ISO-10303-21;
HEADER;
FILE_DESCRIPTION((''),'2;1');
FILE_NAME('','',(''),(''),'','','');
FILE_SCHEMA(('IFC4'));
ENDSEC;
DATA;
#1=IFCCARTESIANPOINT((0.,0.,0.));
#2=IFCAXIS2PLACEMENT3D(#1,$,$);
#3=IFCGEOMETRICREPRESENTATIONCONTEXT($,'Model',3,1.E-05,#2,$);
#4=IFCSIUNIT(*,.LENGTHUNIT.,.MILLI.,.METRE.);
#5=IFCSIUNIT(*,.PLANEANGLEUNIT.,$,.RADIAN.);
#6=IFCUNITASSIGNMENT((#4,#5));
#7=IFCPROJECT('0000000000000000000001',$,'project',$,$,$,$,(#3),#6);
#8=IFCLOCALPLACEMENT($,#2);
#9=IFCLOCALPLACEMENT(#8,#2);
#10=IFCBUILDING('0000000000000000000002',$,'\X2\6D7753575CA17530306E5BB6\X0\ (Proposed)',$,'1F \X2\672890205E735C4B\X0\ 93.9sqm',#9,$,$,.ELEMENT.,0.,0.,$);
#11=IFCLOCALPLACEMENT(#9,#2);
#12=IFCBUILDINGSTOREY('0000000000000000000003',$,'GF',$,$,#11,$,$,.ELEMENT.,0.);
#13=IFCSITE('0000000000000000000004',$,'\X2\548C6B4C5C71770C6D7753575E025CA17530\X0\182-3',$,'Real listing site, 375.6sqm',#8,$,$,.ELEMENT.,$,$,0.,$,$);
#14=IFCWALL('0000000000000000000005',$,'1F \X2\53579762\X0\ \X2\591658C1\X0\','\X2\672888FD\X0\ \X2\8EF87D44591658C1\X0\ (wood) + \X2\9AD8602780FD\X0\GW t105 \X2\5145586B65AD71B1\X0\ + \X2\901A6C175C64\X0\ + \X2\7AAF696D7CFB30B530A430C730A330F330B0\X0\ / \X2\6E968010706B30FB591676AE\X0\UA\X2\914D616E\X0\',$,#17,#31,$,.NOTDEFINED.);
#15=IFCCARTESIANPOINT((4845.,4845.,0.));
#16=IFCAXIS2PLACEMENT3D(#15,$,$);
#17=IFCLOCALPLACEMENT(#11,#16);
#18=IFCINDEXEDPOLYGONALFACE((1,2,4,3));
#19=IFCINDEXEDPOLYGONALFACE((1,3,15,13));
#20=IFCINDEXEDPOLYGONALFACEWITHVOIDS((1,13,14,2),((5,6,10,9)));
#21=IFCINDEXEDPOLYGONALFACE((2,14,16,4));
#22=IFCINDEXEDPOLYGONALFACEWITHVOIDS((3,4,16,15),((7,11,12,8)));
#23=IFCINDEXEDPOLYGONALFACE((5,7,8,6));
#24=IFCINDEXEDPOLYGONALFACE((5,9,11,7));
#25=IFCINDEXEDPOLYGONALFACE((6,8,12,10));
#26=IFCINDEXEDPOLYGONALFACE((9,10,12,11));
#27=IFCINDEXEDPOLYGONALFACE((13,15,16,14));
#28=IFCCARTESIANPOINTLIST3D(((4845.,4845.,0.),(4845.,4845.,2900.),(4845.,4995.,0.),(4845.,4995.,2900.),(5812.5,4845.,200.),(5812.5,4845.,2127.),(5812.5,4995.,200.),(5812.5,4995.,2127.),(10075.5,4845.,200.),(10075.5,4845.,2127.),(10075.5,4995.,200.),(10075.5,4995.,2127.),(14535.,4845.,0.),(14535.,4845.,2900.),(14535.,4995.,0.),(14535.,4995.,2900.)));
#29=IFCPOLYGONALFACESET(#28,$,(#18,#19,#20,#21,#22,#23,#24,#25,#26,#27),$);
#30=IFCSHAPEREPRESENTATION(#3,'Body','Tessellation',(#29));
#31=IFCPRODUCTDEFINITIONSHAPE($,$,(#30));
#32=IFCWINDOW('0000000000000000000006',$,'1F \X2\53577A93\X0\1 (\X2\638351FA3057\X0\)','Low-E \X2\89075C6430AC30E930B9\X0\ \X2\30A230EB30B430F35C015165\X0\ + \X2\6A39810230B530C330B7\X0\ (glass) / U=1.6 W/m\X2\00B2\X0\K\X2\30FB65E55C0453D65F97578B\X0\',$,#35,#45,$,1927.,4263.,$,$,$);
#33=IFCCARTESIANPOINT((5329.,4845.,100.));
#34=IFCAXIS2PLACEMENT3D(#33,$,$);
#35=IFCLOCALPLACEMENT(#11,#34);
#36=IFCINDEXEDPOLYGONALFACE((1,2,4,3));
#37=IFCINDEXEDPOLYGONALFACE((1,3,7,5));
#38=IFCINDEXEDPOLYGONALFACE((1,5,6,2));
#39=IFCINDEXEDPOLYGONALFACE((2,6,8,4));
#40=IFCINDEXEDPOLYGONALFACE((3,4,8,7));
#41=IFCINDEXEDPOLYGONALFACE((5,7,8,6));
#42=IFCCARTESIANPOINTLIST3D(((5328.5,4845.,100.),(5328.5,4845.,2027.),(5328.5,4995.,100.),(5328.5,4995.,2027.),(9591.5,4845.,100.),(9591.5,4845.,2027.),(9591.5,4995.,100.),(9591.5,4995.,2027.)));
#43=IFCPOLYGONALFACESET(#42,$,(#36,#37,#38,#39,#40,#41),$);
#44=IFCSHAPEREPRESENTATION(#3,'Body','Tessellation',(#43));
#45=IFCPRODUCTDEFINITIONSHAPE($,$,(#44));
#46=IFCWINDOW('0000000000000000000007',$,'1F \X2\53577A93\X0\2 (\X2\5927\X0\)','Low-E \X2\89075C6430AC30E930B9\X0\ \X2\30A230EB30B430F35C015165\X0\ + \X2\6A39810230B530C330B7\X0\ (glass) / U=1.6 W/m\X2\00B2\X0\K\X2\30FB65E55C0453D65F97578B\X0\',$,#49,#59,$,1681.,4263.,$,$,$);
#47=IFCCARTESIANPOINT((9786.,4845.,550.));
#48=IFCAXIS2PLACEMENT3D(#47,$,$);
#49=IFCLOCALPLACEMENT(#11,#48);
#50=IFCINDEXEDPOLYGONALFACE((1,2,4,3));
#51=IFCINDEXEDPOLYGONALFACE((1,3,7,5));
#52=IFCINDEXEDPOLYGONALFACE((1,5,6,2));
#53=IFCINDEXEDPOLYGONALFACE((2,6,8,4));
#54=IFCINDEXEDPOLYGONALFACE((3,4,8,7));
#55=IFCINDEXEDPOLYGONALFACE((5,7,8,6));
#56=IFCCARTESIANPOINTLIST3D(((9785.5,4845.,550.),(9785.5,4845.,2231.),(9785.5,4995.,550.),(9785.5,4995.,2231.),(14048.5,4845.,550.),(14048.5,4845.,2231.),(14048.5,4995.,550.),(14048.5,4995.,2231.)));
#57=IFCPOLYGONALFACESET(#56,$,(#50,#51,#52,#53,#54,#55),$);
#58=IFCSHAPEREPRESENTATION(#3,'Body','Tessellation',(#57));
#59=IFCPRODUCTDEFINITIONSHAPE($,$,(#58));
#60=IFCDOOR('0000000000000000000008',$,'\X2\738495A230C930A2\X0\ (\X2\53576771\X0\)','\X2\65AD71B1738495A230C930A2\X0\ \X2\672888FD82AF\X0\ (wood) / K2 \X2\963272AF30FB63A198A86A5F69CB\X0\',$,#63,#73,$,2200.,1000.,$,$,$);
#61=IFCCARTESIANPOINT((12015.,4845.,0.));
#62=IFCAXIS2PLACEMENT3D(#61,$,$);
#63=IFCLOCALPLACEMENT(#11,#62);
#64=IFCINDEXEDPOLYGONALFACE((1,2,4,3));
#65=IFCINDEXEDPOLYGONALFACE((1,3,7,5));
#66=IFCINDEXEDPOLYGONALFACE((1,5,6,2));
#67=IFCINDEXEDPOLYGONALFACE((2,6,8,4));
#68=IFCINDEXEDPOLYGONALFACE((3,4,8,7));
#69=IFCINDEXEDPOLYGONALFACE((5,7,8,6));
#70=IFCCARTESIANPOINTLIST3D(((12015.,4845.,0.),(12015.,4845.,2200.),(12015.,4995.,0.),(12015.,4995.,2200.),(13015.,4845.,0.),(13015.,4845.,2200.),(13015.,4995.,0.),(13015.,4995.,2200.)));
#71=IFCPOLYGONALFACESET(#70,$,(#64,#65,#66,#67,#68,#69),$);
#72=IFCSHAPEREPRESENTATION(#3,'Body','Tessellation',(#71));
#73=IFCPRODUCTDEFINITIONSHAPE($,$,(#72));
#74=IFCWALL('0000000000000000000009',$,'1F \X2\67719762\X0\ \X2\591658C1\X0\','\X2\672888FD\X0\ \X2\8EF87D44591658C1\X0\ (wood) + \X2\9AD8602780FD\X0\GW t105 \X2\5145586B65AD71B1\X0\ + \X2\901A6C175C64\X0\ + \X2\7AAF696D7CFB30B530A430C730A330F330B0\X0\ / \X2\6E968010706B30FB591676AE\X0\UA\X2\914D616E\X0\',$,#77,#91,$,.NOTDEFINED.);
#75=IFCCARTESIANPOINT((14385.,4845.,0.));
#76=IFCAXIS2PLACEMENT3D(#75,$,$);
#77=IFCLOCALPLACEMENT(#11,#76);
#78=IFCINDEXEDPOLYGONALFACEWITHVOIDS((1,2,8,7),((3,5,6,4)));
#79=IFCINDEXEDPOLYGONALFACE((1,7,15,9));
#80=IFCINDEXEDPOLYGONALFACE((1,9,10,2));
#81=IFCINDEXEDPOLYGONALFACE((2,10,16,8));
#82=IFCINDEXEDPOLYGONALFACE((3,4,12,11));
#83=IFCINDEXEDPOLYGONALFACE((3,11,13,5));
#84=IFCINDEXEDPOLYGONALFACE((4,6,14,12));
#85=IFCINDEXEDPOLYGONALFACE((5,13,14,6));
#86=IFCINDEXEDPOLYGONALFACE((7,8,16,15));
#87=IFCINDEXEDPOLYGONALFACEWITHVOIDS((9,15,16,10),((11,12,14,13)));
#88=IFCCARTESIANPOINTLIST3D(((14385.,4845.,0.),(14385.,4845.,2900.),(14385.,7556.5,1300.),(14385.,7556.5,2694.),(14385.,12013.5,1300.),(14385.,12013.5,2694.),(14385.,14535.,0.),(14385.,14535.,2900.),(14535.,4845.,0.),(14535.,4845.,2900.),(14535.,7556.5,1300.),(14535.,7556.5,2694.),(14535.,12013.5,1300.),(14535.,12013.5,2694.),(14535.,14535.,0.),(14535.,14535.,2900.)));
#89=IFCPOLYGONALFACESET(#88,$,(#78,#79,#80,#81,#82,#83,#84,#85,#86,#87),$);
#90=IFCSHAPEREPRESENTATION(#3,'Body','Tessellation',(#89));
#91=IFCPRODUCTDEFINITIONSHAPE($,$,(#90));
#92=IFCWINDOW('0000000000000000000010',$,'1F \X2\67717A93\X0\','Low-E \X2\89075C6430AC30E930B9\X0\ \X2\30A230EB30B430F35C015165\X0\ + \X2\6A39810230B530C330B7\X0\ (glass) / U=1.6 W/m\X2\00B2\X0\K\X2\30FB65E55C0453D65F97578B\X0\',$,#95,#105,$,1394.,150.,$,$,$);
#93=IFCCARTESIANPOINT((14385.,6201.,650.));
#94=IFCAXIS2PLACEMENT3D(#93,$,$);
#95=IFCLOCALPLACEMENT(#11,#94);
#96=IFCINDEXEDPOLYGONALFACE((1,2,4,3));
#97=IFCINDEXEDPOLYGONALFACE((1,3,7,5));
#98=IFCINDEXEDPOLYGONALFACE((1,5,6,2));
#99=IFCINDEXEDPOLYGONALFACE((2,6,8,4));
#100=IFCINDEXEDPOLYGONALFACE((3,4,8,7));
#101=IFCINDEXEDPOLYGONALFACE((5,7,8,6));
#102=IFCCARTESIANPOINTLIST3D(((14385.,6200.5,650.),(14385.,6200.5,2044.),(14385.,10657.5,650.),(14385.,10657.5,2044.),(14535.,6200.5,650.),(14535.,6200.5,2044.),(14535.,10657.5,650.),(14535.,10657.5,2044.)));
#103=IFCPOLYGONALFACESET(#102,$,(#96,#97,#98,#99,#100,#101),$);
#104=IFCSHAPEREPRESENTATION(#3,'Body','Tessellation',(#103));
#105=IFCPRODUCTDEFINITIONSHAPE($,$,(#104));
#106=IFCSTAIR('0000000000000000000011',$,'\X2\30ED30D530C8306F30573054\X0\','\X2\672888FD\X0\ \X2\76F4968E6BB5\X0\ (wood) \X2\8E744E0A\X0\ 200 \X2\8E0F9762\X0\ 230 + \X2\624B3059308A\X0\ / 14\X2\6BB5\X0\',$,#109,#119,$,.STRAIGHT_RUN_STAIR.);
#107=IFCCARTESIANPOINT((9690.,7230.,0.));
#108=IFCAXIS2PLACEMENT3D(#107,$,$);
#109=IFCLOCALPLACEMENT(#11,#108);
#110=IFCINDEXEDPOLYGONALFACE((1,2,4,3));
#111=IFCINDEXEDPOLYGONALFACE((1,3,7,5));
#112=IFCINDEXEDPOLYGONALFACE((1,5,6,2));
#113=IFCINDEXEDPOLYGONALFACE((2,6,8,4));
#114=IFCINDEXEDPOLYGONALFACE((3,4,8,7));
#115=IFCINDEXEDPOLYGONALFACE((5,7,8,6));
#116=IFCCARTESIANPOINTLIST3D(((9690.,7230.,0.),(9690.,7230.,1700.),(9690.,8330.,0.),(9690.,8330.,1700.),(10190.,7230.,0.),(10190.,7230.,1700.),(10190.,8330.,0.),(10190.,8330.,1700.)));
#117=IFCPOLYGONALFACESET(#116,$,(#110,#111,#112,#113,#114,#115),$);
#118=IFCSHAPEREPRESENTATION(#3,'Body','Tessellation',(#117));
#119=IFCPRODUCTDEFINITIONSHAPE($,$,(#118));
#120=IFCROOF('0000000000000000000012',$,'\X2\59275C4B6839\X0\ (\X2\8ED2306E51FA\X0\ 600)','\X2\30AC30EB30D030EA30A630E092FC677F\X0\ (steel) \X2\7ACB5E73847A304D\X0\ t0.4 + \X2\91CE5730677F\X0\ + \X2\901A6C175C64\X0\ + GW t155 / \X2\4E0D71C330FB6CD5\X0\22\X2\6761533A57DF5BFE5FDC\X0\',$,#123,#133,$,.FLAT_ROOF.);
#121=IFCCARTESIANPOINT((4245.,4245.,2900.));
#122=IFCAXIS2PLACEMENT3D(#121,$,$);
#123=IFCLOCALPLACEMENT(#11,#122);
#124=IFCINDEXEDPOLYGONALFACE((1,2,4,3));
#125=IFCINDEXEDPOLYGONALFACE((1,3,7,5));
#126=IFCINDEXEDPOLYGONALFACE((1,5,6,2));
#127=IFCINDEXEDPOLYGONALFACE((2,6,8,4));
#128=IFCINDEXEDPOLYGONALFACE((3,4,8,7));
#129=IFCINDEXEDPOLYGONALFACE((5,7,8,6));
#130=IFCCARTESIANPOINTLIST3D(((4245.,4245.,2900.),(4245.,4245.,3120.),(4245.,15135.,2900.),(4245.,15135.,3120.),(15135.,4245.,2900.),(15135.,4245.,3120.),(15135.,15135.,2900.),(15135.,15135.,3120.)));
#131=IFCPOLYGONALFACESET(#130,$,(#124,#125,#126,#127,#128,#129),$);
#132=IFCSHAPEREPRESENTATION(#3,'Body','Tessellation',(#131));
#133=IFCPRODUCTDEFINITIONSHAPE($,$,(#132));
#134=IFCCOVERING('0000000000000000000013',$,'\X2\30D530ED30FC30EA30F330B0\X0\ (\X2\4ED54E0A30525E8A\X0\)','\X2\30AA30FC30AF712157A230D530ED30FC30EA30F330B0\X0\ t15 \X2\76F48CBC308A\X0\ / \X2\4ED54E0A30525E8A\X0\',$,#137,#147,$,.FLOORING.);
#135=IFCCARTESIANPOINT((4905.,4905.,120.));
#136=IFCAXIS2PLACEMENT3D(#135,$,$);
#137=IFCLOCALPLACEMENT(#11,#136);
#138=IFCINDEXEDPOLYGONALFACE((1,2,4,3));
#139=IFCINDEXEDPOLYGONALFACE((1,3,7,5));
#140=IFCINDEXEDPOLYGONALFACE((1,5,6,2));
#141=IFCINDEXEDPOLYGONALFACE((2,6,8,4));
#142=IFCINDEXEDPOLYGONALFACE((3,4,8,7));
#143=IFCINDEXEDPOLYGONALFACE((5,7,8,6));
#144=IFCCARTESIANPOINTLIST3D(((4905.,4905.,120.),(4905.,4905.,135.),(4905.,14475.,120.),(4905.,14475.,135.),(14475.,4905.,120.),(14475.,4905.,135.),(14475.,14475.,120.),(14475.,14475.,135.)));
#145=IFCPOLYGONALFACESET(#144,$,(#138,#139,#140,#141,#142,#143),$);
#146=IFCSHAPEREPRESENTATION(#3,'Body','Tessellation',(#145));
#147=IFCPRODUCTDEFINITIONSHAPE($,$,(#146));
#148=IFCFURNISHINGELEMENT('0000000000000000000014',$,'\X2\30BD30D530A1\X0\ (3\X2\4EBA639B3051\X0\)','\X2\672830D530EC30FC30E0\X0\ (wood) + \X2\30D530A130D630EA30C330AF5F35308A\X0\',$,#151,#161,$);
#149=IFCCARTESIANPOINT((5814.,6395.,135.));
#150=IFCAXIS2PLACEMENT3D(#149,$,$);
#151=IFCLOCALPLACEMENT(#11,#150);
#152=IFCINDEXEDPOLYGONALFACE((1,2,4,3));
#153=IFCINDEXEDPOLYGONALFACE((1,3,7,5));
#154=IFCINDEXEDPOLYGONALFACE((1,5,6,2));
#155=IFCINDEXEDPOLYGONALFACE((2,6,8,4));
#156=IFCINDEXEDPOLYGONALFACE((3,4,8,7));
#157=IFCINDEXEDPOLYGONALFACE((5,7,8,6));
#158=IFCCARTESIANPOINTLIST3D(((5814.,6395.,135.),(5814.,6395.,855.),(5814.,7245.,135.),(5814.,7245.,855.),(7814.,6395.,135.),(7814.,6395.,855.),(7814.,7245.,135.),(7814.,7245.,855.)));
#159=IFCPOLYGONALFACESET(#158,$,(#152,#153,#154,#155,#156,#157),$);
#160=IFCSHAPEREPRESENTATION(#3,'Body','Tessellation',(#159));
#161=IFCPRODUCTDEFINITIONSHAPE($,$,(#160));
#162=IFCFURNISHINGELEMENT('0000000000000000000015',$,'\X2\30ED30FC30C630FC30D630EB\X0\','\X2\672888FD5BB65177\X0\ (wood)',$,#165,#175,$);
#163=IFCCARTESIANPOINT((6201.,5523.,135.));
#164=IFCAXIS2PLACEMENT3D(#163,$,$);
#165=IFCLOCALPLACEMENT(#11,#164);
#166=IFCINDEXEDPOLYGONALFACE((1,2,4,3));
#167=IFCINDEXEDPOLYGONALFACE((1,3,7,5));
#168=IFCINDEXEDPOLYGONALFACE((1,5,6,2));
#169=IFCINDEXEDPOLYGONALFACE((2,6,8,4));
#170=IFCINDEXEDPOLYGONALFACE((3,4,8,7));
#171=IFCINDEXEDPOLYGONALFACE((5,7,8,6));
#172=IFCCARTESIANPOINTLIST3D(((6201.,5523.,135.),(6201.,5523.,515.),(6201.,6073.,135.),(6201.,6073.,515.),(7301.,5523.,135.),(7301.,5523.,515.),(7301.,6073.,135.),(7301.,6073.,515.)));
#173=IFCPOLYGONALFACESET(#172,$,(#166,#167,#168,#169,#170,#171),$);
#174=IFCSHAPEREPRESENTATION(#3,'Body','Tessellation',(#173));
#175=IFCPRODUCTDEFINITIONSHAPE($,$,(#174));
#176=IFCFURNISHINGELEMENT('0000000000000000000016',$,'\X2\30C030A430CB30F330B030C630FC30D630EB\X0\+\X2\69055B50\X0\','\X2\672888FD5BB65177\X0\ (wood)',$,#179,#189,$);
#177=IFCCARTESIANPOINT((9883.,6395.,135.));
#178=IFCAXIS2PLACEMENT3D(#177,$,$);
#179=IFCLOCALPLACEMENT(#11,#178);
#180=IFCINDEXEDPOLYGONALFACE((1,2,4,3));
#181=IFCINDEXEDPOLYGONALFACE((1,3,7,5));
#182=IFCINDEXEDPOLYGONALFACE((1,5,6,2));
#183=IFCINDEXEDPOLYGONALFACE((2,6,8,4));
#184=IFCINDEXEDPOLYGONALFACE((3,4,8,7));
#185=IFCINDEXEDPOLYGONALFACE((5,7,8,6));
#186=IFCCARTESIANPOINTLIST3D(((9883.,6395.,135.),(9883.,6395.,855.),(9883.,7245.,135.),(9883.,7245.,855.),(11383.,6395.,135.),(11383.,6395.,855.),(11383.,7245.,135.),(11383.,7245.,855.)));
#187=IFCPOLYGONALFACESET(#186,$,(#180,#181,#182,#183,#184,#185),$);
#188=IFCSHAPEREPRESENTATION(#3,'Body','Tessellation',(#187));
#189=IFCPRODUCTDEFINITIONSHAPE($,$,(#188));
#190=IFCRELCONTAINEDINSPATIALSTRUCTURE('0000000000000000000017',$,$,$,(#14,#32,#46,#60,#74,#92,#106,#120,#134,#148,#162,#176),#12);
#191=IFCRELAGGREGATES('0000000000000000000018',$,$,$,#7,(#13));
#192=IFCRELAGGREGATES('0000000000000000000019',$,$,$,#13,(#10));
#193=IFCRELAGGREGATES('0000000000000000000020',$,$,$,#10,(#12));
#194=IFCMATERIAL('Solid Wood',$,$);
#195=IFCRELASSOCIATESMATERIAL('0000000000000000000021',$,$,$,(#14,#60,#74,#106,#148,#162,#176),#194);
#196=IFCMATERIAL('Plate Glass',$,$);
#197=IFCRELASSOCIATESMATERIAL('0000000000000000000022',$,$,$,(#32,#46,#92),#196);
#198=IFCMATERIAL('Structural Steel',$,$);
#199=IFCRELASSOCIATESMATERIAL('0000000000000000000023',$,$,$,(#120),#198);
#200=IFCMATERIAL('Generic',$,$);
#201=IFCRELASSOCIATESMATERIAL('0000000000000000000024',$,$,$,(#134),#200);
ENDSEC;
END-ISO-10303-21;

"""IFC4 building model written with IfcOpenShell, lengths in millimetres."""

from ifc_helpers import new_model, si_unit, frame, frame_2d, origin, place, context, project, spatial, rectangle, extrude, material, element, fill, save


model = new_model("IFC4")

# Units and contexts
model_context = context("Model", 3, precision=1e-05, world=origin())
ifc_project = project(units=[si_unit("LENGTHUNIT", "METRE", prefix="MILLI"), si_unit("PLANEANGLEUNIT", "RADIAN")], contexts=[model_context])

# Site, building, storey
site_placement = place(None, origin())
site = spatial("IfcSite", under=ifc_project, at=site_placement, Name="和歌山県海南市岡田182-3", ObjectType="Real listing site, 375.6sqm", CompositionType="ELEMENT", RefElevation=0.0)
building_placement = place(site_placement, origin())
building = spatial("IfcBuilding", under=site, at=building_placement, Name="海南岡田の家 (Proposed)", ObjectType="1F 木造平屋 93.9sqm", CompositionType="ELEMENT", ElevationOfRefHeight=0.0, ElevationOfTerrain=0.0)
storey_placement = place(building_placement, origin())
storey = spatial("IfcBuildingStorey", under=building, at=storey_placement, Name="GF", CompositionType="ELEMENT", Elevation=0.0)

# Shared definitions
ifc_material_1 = material(Name="Solid Wood")

# Wall, openings, windows, door
wall_1_placement = place(storey_placement, frame((4845.0, 4845.0, 0.0)))
wall_1 = element("IfcWall", 1, at=wall_1_placement, inside=storey, material=ifc_material_1, Name="1F 南面 外壁", Description="木製 軸組外壁 (wood) + 高性能GW t105 充填断熱 + 通気層 + 窯業系サイディング / 準耐火・外皮UA配慮", PredefinedType="NOTDEFINED", context=model_context, shape_type="SweptSolid", body=[
    extrude(rectangle(XDim=9690.0, YDim=150.0, at=frame_2d((4845.0, 75.0))), frame((4845.0, 4845.0, 0.0)), (0.0, 0.0, 1.0), 2900.0),
])
opening_1_placement = place(storey_placement, frame((5329.0, 4845.0, 100.0)))
opening_1 = element("IfcOpeningElement", 2, at=opening_1_placement, cuts=wall_1, PredefinedType="NOTDEFINED", context=model_context, shape_type="SweptSolid", body=[
    extrude(rectangle(XDim=4263.0, YDim=150.0, at=frame_2d((2131.0, 75.0))), frame((5329.0, 4845.0, 100.0)), (0.0, 0.0, 1.0), 1927.0),
])
opening_2_placement = place(storey_placement, frame((9786.0, 4845.0, 550.0)))
opening_2 = element("IfcOpeningElement", 3, at=opening_2_placement, cuts=wall_1, PredefinedType="NOTDEFINED", context=model_context, shape_type="SweptSolid", body=[
    extrude(rectangle(XDim=4263.0, YDim=150.0, at=frame_2d((2131.0, 75.0))), frame((9786.0, 4845.0, 550.0)), (0.0, 0.0, 1.0), 1681.0),
])
opening_3_placement = place(storey_placement, frame((12015.0, 4845.0, 0.0)))
opening_3 = element("IfcOpeningElement", 4, at=opening_3_placement, cuts=wall_1, PredefinedType="NOTDEFINED", context=model_context, shape_type="SweptSolid", body=[
    extrude(rectangle(XDim=1000.0, YDim=150.0, at=frame_2d((500.0, 75.0))), frame((12015.0, 4845.0, 0.0)), (0.0, 0.0, 1.0), 2200.0),
])
ifc_material_2 = material(Name="Plate Glass")
window_1_placement = place(storey_placement, frame((5329.0, 4845.0, 100.0)))
window_1 = element("IfcWindow", 5, at=window_1_placement, inside=storey, material=ifc_material_2, Name="1F 南窓1 (掃出し)", Description="Low-E 複層ガラス アルゴン封入 + 樹脂サッシ (glass) / U=1.6 W/m²K・日射取得型", OverallHeight=1927.0, OverallWidth=4263.0, context=model_context, shape_type="SweptSolid", body=[
    extrude(rectangle(XDim=4263.0, YDim=150.0, at=frame_2d((2131.0, 75.0))), frame((5329.0, 4845.0, 100.0)), (0.0, 0.0, 1.0), 1927.0),
])
fill(opening_1, window_1)
window_2_placement = place(storey_placement, frame((9786.0, 4845.0, 550.0)))
window_2 = element("IfcWindow", 6, at=window_2_placement, inside=storey, material=ifc_material_2, Name="1F 南窓2 (大)", Description="Low-E 複層ガラス アルゴン封入 + 樹脂サッシ (glass) / U=1.6 W/m²K・日射取得型", OverallHeight=1681.0, OverallWidth=4263.0, context=model_context, shape_type="SweptSolid", body=[
    extrude(rectangle(XDim=4263.0, YDim=150.0, at=frame_2d((2131.0, 75.0))), frame((9786.0, 4845.0, 550.0)), (0.0, 0.0, 1.0), 1681.0),
])
fill(opening_2, window_2)
door_placement = place(storey_placement, frame((12015.0, 4845.0, 0.0)))
door = element("IfcDoor", 7, at=door_placement, inside=storey, material=ifc_material_1, Name="玄関ドア (南東)", Description="断熱玄関ドア 木製芯 (wood) / K2 防犯・採風機構", OverallHeight=2200.0, OverallWidth=1000.0, context=model_context, shape_type="SweptSolid", body=[
    extrude(rectangle(XDim=1000.0, YDim=150.0, at=frame_2d((500.0, 75.0))), frame((12015.0, 4845.0, 0.0)), (0.0, 0.0, 1.0), 2200.0),
])
fill(opening_3, door)

# Wall, opening, window
wall_2_placement = place(storey_placement, frame((14385.0, 4845.0, 0.0)))
wall_2 = element("IfcWall", 8, at=wall_2_placement, inside=storey, material=ifc_material_1, Name="1F 東面 外壁", Description="木製 軸組外壁 (wood) + 高性能GW t105 充填断熱 + 通気層 + 窯業系サイディング / 準耐火・外皮UA配慮", PredefinedType="NOTDEFINED", context=model_context, shape_type="SweptSolid", body=[
    extrude(rectangle(XDim=150.0, YDim=9690.0, at=frame_2d((75.0, 4845.0))), frame((14385.0, 4845.0, 0.0)), (0.0, 0.0, 1.0), 2900.0),
])
opening_4_placement = place(storey_placement, frame((14385.0, 6201.0, 650.0)))
opening_4 = element("IfcOpeningElement", 9, at=opening_4_placement, cuts=wall_2, PredefinedType="NOTDEFINED", context=model_context, shape_type="SweptSolid", body=[
    extrude(rectangle(XDim=150.0, YDim=4457.0, at=frame_2d((75.0, 2228.0))), frame((14385.0, 6201.0, 650.0)), (0.0, 0.0, 1.0), 1394.0),
])
window_3_placement = place(storey_placement, frame((14385.0, 6201.0, 650.0)))
window_3 = element("IfcWindow", 10, at=window_3_placement, inside=storey, material=ifc_material_2, Name="1F 東窓", Description="Low-E 複層ガラス アルゴン封入 + 樹脂サッシ (glass) / U=1.6 W/m²K・日射取得型", OverallHeight=1394.0, OverallWidth=150.0, context=model_context, shape_type="SweptSolid", body=[
    extrude(rectangle(XDim=150.0, YDim=4457.0, at=frame_2d((75.0, 2228.0))), frame((14385.0, 6201.0, 650.0)), (0.0, 0.0, 1.0), 1394.0),
])
fill(opening_4, window_3)

# Stair
stair_placement = place(storey_placement, frame((9690.0, 7230.0, 0.0)))
element("IfcStair", 11, at=stair_placement, inside=storey, material=ifc_material_1, Name="ロフトはしご", Description="木製 直階段 (wood) 蹴上 200 踏面 230 + 手すり / 14段", PredefinedType="STRAIGHT_RUN_STAIR", context=model_context, shape_type="SweptSolid", body=[
    extrude(rectangle(XDim=500.0, YDim=1100.0, at=frame_2d((250.0, 550.0))), frame((9690.0, 7230.0, 0.0)), (0.0, 0.0, 1.0), 1700.0),
])

# Roof
ifc_material_3 = material(Name="Structural Steel")
roof_placement = place(storey_placement, frame((4245.0, 4245.0, 2900.0)))
element("IfcRoof", 12, at=roof_placement, inside=storey, material=ifc_material_3, Name="大屋根 (軒の出 600)", Description="ガルバリウム鋼板 (steel) 立平葺き t0.4 + 野地板 + 通気層 + GW t155 / 不燃・法22条区域対応", PredefinedType="FLAT_ROOF", context=model_context, shape_type="SweptSolid", body=[
    extrude(rectangle(XDim=10890.0, YDim=10890.0, at=frame_2d((5445.0, 5445.0))), frame((4245.0, 4245.0, 2900.0)), (0.0, 0.0, 1.0), 220.0),
])

# Covering
ifc_material_4 = material(Name="Generic")
covering_placement = place(storey_placement, frame((4905.0, 4905.0, 120.0)))
element("IfcCovering", 13, at=covering_placement, inside=storey, material=ifc_material_4, Name="フローリング (仕上げ床)", Description="オーク無垢フローリング t15 直貼り / 仕上げ床", PredefinedType="FLOORING", context=model_context, shape_type="SweptSolid", body=[
    extrude(rectangle(XDim=9570.0, YDim=9570.0, at=frame_2d((4785.0, 4785.0))), frame((4905.0, 4905.0, 120.0)), (0.0, 0.0, 1.0), 15.0),
])

# Furnishing elements
furnishing_1_placement = place(storey_placement, frame((5814.0, 6395.0, 135.0)))
element("IfcFurnishingElement", 14, at=furnishing_1_placement, inside=storey, material=ifc_material_1, Name="ソファ (3人掛け)", Description="木フレーム (wood) + ファブリック張り", context=model_context, shape_type="SweptSolid", body=[
    extrude(rectangle(XDim=2000.0, YDim=850.0, at=frame_2d((1000.0, 425.0))), frame((5814.0, 6395.0, 135.0)), (0.0, 0.0, 1.0), 720.0),
])
furnishing_2_placement = place(storey_placement, frame((6201.0, 5523.0, 135.0)))
element("IfcFurnishingElement", 15, at=furnishing_2_placement, inside=storey, material=ifc_material_1, Name="ローテーブル", Description="木製家具 (wood)", context=model_context, shape_type="SweptSolid", body=[
    extrude(rectangle(XDim=1100.0, YDim=550.0, at=frame_2d((550.0, 275.0))), frame((6201.0, 5523.0, 135.0)), (0.0, 0.0, 1.0), 380.0),
])
furnishing_3_placement = place(storey_placement, frame((9883.0, 6395.0, 135.0)))
element("IfcFurnishingElement", 16, at=furnishing_3_placement, inside=storey, material=ifc_material_1, Name="ダイニングテーブル+椅子", Description="木製家具 (wood)", context=model_context, shape_type="SweptSolid", body=[
    extrude(rectangle(XDim=1500.0, YDim=850.0, at=frame_2d((750.0, 425.0))), frame((9883.0, 6395.0, 135.0)), (0.0, 0.0, 1.0), 720.0),
])

save(model, "model.ifc")
